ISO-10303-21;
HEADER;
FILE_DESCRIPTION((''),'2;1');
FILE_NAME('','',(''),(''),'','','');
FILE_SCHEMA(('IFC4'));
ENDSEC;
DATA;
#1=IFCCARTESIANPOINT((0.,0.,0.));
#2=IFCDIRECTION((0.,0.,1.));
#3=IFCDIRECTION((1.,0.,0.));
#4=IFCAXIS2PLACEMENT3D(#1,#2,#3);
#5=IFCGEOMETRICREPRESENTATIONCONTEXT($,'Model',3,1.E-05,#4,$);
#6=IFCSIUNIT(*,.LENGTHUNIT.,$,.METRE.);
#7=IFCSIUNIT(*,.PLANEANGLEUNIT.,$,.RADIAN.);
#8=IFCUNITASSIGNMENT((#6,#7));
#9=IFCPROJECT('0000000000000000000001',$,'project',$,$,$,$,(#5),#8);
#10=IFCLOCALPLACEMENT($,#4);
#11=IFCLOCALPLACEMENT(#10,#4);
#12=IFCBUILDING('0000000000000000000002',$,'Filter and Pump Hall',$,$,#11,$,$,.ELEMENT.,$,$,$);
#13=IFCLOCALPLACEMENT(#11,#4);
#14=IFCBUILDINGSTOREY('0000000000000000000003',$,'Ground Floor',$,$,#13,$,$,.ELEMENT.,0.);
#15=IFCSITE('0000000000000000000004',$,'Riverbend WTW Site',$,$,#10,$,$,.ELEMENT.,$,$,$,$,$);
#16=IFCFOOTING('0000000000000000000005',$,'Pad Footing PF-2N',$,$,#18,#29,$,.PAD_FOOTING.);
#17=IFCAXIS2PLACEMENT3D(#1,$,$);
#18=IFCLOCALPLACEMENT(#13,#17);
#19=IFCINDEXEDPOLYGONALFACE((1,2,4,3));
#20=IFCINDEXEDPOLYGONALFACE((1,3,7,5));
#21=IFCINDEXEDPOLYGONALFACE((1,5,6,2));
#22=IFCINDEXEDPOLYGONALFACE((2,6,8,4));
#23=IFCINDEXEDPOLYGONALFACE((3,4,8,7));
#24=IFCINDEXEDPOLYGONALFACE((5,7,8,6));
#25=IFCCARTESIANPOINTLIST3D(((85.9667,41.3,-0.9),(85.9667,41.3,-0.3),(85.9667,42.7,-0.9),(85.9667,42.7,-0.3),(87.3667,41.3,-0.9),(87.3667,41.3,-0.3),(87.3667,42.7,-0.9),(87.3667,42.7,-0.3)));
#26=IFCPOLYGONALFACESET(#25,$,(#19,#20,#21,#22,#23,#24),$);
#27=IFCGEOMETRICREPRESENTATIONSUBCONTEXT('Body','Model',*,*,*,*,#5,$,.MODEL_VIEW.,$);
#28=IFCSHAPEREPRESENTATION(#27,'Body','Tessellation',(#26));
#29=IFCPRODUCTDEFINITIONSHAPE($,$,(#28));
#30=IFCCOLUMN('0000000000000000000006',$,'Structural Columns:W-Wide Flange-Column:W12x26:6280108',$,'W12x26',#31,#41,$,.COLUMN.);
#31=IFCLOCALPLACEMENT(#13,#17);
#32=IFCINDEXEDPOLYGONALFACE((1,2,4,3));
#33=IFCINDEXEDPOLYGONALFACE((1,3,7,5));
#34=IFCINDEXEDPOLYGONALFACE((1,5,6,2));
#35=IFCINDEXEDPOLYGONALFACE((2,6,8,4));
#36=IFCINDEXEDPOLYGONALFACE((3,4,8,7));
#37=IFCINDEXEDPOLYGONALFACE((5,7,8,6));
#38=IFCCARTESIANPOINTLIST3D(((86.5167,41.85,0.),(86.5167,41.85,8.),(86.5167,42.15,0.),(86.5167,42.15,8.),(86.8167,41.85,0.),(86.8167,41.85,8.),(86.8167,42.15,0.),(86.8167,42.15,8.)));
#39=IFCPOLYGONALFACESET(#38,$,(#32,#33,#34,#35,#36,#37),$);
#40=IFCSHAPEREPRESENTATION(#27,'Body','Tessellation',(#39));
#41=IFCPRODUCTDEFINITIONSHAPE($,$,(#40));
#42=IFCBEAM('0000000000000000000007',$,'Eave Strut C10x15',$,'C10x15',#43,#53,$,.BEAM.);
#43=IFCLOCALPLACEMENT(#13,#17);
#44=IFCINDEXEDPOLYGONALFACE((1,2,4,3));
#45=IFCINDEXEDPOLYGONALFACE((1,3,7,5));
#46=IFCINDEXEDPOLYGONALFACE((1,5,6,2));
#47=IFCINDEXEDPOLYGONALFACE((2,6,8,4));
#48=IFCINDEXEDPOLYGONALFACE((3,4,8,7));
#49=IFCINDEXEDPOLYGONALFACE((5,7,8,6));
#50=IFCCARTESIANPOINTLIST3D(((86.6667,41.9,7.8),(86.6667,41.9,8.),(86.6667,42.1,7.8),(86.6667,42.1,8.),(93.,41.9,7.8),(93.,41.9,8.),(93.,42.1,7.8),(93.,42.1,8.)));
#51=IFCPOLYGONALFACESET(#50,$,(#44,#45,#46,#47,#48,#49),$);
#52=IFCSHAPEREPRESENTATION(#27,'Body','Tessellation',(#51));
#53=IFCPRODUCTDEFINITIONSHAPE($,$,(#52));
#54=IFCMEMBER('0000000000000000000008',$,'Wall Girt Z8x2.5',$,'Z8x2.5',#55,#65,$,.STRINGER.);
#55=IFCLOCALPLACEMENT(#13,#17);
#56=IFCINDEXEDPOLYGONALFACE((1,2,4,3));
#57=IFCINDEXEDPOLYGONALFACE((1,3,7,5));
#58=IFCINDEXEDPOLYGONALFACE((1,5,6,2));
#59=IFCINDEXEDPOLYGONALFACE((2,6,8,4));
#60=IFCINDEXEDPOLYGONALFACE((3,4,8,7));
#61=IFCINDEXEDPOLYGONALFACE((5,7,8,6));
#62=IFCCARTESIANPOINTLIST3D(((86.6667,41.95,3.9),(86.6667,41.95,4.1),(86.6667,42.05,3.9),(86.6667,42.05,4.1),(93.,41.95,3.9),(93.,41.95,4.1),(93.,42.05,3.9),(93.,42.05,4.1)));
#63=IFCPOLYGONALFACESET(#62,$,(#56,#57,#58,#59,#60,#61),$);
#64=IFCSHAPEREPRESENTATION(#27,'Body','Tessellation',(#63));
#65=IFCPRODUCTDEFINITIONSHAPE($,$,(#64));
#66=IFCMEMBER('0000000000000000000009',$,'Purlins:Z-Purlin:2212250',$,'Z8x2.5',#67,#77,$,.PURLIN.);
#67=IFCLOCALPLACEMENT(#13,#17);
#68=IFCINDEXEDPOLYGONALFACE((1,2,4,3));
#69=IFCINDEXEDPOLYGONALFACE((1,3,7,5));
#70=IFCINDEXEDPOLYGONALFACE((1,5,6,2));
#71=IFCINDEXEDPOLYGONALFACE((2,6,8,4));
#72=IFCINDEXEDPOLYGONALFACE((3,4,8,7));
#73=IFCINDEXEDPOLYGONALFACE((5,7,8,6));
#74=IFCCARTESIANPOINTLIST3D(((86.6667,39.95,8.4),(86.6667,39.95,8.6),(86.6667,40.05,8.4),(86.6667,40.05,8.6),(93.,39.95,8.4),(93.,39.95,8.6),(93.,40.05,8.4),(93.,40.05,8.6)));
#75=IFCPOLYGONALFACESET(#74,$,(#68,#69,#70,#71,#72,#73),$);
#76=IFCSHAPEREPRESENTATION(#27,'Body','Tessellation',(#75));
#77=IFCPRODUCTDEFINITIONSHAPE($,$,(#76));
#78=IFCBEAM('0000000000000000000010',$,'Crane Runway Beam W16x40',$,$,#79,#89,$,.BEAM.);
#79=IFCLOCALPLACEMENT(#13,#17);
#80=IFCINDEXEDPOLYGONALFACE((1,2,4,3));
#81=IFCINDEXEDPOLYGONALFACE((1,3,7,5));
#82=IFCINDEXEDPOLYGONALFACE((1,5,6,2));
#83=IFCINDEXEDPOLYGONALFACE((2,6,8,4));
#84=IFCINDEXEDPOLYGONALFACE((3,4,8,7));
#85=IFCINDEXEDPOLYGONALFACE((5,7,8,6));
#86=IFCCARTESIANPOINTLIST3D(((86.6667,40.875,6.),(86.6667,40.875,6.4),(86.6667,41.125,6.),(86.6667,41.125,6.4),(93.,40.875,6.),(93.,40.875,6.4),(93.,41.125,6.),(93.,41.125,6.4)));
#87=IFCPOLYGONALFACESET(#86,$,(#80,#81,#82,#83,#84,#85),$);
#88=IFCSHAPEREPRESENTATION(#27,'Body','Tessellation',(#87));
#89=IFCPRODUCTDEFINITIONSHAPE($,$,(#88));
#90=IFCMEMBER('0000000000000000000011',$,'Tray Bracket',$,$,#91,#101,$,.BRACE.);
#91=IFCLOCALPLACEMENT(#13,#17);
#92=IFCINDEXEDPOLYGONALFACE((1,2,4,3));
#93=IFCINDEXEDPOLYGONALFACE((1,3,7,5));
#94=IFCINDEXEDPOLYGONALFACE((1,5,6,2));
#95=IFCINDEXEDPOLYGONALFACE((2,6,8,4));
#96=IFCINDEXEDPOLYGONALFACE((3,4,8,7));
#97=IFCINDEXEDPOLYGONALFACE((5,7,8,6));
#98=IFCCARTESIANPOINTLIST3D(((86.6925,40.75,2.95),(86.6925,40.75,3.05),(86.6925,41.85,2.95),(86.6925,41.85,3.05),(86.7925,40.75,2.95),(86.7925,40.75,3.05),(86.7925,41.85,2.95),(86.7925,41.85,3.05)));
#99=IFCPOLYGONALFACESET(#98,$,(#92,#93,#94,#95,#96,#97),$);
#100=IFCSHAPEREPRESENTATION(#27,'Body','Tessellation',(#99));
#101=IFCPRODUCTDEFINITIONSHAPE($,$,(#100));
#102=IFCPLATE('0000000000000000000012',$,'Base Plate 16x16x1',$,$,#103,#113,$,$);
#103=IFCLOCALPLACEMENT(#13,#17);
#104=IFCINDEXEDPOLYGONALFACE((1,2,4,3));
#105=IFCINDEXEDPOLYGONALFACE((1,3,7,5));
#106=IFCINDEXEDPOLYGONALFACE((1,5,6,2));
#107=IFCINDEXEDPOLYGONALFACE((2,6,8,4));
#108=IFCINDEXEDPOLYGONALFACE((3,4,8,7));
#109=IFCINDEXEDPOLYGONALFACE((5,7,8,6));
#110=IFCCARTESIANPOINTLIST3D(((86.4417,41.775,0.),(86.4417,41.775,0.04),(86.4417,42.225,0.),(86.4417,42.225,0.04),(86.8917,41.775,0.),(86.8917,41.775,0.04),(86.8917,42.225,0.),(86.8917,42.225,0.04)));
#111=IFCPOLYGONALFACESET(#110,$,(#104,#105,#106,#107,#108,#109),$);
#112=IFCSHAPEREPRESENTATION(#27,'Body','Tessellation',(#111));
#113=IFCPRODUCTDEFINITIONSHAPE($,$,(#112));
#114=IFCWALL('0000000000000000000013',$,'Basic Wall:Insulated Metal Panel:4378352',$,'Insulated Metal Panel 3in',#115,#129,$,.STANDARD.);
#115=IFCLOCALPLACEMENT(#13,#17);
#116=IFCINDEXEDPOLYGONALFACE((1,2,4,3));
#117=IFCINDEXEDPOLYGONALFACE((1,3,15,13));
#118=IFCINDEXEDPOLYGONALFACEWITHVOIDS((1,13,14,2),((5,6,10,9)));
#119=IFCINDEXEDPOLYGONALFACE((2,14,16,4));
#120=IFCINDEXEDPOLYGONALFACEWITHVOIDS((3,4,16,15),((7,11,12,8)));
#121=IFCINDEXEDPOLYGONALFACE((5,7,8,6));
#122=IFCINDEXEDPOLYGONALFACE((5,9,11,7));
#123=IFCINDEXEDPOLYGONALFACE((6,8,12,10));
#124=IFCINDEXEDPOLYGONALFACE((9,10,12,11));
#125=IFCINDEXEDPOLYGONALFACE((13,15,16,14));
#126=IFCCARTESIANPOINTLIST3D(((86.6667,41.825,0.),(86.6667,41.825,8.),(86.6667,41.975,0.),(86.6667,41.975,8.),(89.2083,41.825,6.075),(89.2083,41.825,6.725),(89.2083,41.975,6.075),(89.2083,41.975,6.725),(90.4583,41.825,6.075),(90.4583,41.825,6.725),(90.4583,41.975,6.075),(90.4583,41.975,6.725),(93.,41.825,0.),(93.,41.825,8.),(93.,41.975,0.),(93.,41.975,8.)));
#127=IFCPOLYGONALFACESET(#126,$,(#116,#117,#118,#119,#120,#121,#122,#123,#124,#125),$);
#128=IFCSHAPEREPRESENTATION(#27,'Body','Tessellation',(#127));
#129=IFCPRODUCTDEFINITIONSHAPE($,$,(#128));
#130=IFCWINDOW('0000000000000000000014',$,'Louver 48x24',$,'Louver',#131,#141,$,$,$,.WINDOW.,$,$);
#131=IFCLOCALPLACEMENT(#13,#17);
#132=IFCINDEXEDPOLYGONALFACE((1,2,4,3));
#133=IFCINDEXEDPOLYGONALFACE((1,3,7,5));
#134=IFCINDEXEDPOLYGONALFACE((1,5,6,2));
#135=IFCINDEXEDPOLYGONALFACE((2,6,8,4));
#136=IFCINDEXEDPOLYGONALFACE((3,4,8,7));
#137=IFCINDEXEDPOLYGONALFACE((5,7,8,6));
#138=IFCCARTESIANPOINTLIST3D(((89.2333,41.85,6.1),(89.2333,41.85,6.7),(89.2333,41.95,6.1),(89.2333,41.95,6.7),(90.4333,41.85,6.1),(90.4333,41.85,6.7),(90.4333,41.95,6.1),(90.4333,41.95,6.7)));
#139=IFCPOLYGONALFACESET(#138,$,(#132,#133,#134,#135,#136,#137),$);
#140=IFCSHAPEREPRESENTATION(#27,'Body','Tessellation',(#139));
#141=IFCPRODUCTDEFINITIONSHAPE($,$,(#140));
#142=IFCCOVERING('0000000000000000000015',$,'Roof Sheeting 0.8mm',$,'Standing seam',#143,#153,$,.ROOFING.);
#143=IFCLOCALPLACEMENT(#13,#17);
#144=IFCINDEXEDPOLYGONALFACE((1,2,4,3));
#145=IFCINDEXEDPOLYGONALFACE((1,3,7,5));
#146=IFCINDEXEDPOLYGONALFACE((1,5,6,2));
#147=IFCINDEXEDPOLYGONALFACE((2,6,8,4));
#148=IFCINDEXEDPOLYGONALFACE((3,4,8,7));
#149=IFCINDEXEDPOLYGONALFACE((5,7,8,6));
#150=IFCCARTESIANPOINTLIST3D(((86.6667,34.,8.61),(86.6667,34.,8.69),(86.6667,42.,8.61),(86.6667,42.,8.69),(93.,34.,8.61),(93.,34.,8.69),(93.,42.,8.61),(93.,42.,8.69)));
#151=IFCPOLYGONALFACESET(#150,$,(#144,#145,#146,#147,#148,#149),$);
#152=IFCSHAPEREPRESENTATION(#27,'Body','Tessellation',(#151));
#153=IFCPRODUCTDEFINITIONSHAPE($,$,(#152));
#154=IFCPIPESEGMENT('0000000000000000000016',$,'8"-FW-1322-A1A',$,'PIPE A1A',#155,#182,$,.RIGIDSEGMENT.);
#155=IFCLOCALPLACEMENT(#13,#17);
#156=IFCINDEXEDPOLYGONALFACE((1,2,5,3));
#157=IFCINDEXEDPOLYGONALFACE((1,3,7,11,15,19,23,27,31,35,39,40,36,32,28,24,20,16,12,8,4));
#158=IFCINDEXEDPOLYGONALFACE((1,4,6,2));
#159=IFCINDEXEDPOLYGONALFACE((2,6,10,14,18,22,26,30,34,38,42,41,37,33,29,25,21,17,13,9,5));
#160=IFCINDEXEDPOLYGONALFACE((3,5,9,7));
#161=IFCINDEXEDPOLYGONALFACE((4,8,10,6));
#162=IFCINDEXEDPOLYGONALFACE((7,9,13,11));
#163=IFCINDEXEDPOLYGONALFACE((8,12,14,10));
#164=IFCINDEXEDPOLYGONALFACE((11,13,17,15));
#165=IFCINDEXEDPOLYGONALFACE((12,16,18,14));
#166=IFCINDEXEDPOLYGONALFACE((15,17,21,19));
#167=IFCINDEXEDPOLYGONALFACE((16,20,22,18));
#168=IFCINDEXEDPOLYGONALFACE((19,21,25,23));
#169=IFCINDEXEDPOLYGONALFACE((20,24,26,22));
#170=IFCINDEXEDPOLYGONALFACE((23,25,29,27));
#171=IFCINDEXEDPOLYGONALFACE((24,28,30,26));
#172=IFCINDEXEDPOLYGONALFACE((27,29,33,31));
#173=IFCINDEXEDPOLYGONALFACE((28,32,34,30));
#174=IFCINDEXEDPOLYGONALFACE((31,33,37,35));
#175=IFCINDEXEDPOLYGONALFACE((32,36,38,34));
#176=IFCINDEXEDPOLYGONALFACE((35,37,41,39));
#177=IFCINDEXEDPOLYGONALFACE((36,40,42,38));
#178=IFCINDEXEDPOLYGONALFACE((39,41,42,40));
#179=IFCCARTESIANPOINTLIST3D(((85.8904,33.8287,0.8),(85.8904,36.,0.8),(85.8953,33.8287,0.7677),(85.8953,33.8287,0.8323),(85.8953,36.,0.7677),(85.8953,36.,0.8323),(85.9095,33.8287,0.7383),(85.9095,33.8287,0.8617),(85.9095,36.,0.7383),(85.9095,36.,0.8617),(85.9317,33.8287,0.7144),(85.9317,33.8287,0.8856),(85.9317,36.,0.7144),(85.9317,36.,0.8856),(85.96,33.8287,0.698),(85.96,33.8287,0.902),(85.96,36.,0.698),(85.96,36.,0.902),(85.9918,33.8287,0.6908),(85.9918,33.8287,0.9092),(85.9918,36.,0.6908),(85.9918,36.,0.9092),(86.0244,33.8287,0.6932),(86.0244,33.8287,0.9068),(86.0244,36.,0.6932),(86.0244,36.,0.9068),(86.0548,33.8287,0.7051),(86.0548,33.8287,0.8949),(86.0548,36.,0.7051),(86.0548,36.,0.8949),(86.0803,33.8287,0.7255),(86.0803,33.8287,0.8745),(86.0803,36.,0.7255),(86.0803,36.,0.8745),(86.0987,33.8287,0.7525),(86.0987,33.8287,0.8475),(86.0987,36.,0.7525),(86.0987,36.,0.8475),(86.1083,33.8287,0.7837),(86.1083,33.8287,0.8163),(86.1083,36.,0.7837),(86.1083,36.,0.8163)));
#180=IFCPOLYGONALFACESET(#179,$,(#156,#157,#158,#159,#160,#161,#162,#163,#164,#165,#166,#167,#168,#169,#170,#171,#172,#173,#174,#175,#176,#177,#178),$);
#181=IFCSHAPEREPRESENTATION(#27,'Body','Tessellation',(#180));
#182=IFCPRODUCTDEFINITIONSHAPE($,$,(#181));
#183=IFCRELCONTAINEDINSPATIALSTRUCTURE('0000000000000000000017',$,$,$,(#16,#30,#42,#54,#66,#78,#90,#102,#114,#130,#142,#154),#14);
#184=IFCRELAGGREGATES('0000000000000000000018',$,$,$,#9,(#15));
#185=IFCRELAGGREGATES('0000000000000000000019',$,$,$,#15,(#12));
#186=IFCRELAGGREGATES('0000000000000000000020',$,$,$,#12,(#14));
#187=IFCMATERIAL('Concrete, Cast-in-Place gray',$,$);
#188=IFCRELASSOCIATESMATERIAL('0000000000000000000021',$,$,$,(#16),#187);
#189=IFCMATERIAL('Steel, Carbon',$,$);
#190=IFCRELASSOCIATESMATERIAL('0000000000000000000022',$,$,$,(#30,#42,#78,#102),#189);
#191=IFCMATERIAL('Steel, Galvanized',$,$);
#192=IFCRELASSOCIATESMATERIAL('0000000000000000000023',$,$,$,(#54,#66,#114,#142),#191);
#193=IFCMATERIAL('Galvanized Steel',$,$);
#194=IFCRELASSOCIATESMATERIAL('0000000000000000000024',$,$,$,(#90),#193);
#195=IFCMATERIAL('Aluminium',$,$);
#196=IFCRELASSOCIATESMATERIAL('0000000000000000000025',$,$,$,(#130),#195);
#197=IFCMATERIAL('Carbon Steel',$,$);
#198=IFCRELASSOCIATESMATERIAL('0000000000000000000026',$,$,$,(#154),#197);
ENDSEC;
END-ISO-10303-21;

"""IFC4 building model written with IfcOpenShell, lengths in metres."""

from ifc_helpers import new_model, si_unit, frame, origin_with_axes, origin_2d, place, context, subcontext, project, spatial, rectangle, circle, extrude, material, element, fill, save


model = new_model("IFC4")

# Units and contexts
model_context = context("Model", 3, precision=1e-05, world=origin_with_axes())
body_context = subcontext(model_context, "Body", "Model", "MODEL_VIEW")
ifc_project = project(units=[si_unit("LENGTHUNIT", "METRE"), si_unit("PLANEANGLEUNIT", "RADIAN")], contexts=[model_context])

# Site, building, storey
site_placement = place(None, origin_with_axes())
site = spatial("IfcSite", under=ifc_project, at=site_placement, Name="Riverbend WTW Site", CompositionType="ELEMENT")
building_placement = place(site_placement, origin_with_axes())
building = spatial("IfcBuilding", under=site, at=building_placement, Name="Filter and Pump Hall", CompositionType="ELEMENT")
storey_placement = place(building_placement, origin_with_axes())
storey = spatial("IfcBuildingStorey", under=building, at=storey_placement, Name="Ground Floor", CompositionType="ELEMENT", Elevation=0.0)

# Footing
ifc_material_1 = material(Name="Concrete, Cast-in-Place gray")
footing_placement = place(None, frame((86.6667, 42.0, -0.6), z_axis=(0.0, 0.0, 1.0), x_axis=(1.0, 0.0, 0.0)))
element("IfcFooting", 1, at=footing_placement, inside=storey, material=ifc_material_1, Name="Pad Footing PF-2N", PredefinedType="PAD_FOOTING", context=body_context, shape_type="SweptSolid", body=[
    extrude(rectangle(XDim=1.4, YDim=1.4, at=origin_2d()), frame((0.0, 0.0, -0.3), z_axis=(0.0, 0.0, 1.0), x_axis=(1.0, 0.0, 0.0)), (0.0, 0.0, 1.0), 0.6),
])

# Column
ifc_material_2 = material(Name="Steel, Carbon")
column_placement = place(None, frame((86.6667, 42.0, 4.0), z_axis=(0.0, 0.0, 1.0), x_axis=(1.0, 0.0, 0.0)))
element("IfcColumn", 2, at=column_placement, inside=storey, material=ifc_material_2, Name="Structural Columns:W-Wide Flange-Column:W12x26:6280108", ObjectType="W12x26", PredefinedType="COLUMN", context=body_context, shape_type="SweptSolid", body=[
    extrude(rectangle(XDim=0.3, YDim=0.3, at=origin_2d()), frame((0.0, 0.0, -4.0), z_axis=(0.0, 0.0, 1.0), x_axis=(1.0, 0.0, 0.0)), (0.0, 0.0, 1.0), 8.0),
])

# Beam
beam_1_placement = place(None, frame((89.8333, 42.0, 7.9), z_axis=(0.0, 0.0, 1.0), x_axis=(1.0, 0.0, 0.0)))
element("IfcBeam", 3, at=beam_1_placement, inside=storey, material=ifc_material_2, Name="Eave Strut C10x15", ObjectType="C10x15", PredefinedType="BEAM", context=body_context, shape_type="SweptSolid", body=[
    extrude(rectangle(XDim=6.3333, YDim=0.2, at=origin_2d()), frame((0.0, 0.0, -0.1), z_axis=(0.0, 0.0, 1.0), x_axis=(1.0, 0.0, 0.0)), (0.0, 0.0, 1.0), 0.2),
])

# Members
ifc_material_3 = material(Name="Steel, Galvanized")
member_1_placement = place(None, frame((89.8333, 42.0, 4.0), z_axis=(0.0, 0.0, 1.0), x_axis=(1.0, 0.0, 0.0)))
element("IfcMember", 4, at=member_1_placement, inside=storey, material=ifc_material_3, Name="Wall Girt Z8x2.5", ObjectType="Z8x2.5", PredefinedType="STRINGER", context=body_context, shape_type="SweptSolid", body=[
    extrude(rectangle(XDim=6.3333, YDim=0.1, at=origin_2d()), frame((0.0, 0.0, -0.1), z_axis=(0.0, 0.0, 1.0), x_axis=(1.0, 0.0, 0.0)), (0.0, 0.0, 1.0), 0.2),
])
member_2_placement = place(None, frame((89.8333, 40.0, 8.5), z_axis=(0.0, 0.0, 1.0), x_axis=(1.0, 0.0, 0.0)))
element("IfcMember", 5, at=member_2_placement, inside=storey, material=ifc_material_3, Name="Purlins:Z-Purlin:2212250", ObjectType="Z8x2.5", PredefinedType="PURLIN", context=body_context, shape_type="SweptSolid", body=[
    extrude(rectangle(XDim=6.3333, YDim=0.1, at=origin_2d()), frame((0.0, 0.0, -0.1), z_axis=(0.0, 0.0, 1.0), x_axis=(1.0, 0.0, 0.0)), (0.0, 0.0, 1.0), 0.2),
])

# Beam
beam_2_placement = place(None, frame((89.8333, 41.0, 6.2), z_axis=(0.0, 0.0, 1.0), x_axis=(1.0, 0.0, 0.0)))
element("IfcBeam", 6, at=beam_2_placement, inside=storey, material=ifc_material_2, Name="Crane Runway Beam W16x40", PredefinedType="BEAM", context=body_context, shape_type="SweptSolid", body=[
    extrude(rectangle(XDim=6.3333, YDim=0.25, at=origin_2d()), frame((0.0, 0.0, -0.2), z_axis=(0.0, 0.0, 1.0), x_axis=(1.0, 0.0, 0.0)), (0.0, 0.0, 1.0), 0.4),
])

# Member
ifc_material_4 = material(Name="Galvanized Steel")
member_3_placement = place(None, frame((86.7425, 41.3, 3.0), z_axis=(0.0, 0.0, 1.0), x_axis=(1.0, 0.0, 0.0)))
element("IfcMember", 7, at=member_3_placement, inside=storey, material=ifc_material_4, Name="Tray Bracket", PredefinedType="BRACE", context=body_context, shape_type="SweptSolid", body=[
    extrude(rectangle(XDim=0.1, YDim=1.1, at=origin_2d()), frame((0.0, 0.0, -0.05), z_axis=(0.0, 0.0, 1.0), x_axis=(1.0, 0.0, 0.0)), (0.0, 0.0, 1.0), 0.1),
])

# Plate
plate_placement = place(None, frame((86.6667, 42.0, 0.02), z_axis=(0.0, 0.0, 1.0), x_axis=(1.0, 0.0, 0.0)))
element("IfcPlate", 8, at=plate_placement, inside=storey, material=ifc_material_2, Name="Base Plate 16x16x1", context=body_context, shape_type="SweptSolid", body=[
    extrude(rectangle(XDim=0.45, YDim=0.45, at=origin_2d()), frame((0.0, 0.0, -0.02), z_axis=(0.0, 0.0, 1.0), x_axis=(1.0, 0.0, 0.0)), (0.0, 0.0, 1.0), 0.04),
])

# Wall, opening, window
wall_placement = place(None, frame((89.8333, 41.9, 4.0), z_axis=(0.0, 0.0, 1.0), x_axis=(1.0, 0.0, 0.0)))
wall = element("IfcWall", 9, at=wall_placement, inside=storey, material=ifc_material_3, Name="Basic Wall:Insulated Metal Panel:4378352", ObjectType="Insulated Metal Panel 3in", PredefinedType="STANDARD", context=body_context, shape_type="SweptSolid", body=[
    extrude(rectangle(XDim=6.3333, YDim=0.15, at=origin_2d()), frame((0.0, 0.0, -4.0), z_axis=(0.0, 0.0, 1.0), x_axis=(1.0, 0.0, 0.0)), (0.0, 0.0, 1.0), 8.0),
])
opening_placement = place(None, frame((89.8333, 41.9, 6.4), z_axis=(0.0, 0.0, 1.0), x_axis=(1.0, 0.0, 0.0)))
opening = element("IfcOpeningElement", 10, at=opening_placement, inside=storey, cuts=wall, context=body_context, shape_type="SweptSolid", body=[
    extrude(rectangle(XDim=1.25, YDim=0.4, at=origin_2d()), frame((0.0, 0.0, -0.325), z_axis=(0.0, 0.0, 1.0), x_axis=(1.0, 0.0, 0.0)), (0.0, 0.0, 1.0), 0.65),
])
ifc_material_5 = material(Name="Aluminium")
window_placement = place(None, frame((89.8333, 41.9, 6.4), z_axis=(0.0, 0.0, 1.0), x_axis=(1.0, 0.0, 0.0)))
window = element("IfcWindow", 11, at=window_placement, inside=storey, material=ifc_material_5, Name="Louver 48x24", ObjectType="Louver", PredefinedType="WINDOW", context=body_context, shape_type="SweptSolid", body=[
    extrude(rectangle(XDim=1.2, YDim=0.1, at=origin_2d()), frame((0.0, 0.0, -0.3), z_axis=(0.0, 0.0, 1.0), x_axis=(1.0, 0.0, 0.0)), (0.0, 0.0, 1.0), 0.6),
])
fill(opening, window)

# Covering
covering_placement = place(None, frame((89.8333, 38.0, 8.65), z_axis=(0.0, 0.0, 1.0), x_axis=(1.0, 0.0, 0.0)))
element("IfcCovering", 12, at=covering_placement, inside=storey, material=ifc_material_3, Name="Roof Sheeting 0.8mm", ObjectType="Standing seam", PredefinedType="ROOFING", context=body_context, shape_type="SweptSolid", body=[
    extrude(rectangle(XDim=6.3333, YDim=8.0, at=origin_2d()), frame((0.0, 0.0, -0.04), z_axis=(0.0, 0.0, 1.0), x_axis=(1.0, 0.0, 0.0)), (0.0, 0.0, 1.0), 0.08),
])

# Pipe segment
ifc_material_6 = material(Name="Carbon Steel")
pipe_segment_1_placement = place(None, frame((86.0, 33.8287, 0.8), z_axis=(0.0, 0.0, 1.0), x_axis=(1.0, 0.0, 0.0)))
element("IfcPipeSegment", 13, at=pipe_segment_1_placement, inside=storey, material=ifc_material_6, Name="8\"-FW-1322-A1A", ObjectType="PIPE A1A", PredefinedType="RIGIDSEGMENT", context=body_context, shape_type="SweptSolid", body=[
    extrude(circle(Radius=0.1095, at=origin_2d()), frame((0.0, 0.0, 0.0), z_axis=(0.0, 1.0, 0.0), x_axis=(-1.0, 0.0, 0.0)), (0.0, 0.0, 1.0), 2.1713),
])

save(model, "model.ifc")
